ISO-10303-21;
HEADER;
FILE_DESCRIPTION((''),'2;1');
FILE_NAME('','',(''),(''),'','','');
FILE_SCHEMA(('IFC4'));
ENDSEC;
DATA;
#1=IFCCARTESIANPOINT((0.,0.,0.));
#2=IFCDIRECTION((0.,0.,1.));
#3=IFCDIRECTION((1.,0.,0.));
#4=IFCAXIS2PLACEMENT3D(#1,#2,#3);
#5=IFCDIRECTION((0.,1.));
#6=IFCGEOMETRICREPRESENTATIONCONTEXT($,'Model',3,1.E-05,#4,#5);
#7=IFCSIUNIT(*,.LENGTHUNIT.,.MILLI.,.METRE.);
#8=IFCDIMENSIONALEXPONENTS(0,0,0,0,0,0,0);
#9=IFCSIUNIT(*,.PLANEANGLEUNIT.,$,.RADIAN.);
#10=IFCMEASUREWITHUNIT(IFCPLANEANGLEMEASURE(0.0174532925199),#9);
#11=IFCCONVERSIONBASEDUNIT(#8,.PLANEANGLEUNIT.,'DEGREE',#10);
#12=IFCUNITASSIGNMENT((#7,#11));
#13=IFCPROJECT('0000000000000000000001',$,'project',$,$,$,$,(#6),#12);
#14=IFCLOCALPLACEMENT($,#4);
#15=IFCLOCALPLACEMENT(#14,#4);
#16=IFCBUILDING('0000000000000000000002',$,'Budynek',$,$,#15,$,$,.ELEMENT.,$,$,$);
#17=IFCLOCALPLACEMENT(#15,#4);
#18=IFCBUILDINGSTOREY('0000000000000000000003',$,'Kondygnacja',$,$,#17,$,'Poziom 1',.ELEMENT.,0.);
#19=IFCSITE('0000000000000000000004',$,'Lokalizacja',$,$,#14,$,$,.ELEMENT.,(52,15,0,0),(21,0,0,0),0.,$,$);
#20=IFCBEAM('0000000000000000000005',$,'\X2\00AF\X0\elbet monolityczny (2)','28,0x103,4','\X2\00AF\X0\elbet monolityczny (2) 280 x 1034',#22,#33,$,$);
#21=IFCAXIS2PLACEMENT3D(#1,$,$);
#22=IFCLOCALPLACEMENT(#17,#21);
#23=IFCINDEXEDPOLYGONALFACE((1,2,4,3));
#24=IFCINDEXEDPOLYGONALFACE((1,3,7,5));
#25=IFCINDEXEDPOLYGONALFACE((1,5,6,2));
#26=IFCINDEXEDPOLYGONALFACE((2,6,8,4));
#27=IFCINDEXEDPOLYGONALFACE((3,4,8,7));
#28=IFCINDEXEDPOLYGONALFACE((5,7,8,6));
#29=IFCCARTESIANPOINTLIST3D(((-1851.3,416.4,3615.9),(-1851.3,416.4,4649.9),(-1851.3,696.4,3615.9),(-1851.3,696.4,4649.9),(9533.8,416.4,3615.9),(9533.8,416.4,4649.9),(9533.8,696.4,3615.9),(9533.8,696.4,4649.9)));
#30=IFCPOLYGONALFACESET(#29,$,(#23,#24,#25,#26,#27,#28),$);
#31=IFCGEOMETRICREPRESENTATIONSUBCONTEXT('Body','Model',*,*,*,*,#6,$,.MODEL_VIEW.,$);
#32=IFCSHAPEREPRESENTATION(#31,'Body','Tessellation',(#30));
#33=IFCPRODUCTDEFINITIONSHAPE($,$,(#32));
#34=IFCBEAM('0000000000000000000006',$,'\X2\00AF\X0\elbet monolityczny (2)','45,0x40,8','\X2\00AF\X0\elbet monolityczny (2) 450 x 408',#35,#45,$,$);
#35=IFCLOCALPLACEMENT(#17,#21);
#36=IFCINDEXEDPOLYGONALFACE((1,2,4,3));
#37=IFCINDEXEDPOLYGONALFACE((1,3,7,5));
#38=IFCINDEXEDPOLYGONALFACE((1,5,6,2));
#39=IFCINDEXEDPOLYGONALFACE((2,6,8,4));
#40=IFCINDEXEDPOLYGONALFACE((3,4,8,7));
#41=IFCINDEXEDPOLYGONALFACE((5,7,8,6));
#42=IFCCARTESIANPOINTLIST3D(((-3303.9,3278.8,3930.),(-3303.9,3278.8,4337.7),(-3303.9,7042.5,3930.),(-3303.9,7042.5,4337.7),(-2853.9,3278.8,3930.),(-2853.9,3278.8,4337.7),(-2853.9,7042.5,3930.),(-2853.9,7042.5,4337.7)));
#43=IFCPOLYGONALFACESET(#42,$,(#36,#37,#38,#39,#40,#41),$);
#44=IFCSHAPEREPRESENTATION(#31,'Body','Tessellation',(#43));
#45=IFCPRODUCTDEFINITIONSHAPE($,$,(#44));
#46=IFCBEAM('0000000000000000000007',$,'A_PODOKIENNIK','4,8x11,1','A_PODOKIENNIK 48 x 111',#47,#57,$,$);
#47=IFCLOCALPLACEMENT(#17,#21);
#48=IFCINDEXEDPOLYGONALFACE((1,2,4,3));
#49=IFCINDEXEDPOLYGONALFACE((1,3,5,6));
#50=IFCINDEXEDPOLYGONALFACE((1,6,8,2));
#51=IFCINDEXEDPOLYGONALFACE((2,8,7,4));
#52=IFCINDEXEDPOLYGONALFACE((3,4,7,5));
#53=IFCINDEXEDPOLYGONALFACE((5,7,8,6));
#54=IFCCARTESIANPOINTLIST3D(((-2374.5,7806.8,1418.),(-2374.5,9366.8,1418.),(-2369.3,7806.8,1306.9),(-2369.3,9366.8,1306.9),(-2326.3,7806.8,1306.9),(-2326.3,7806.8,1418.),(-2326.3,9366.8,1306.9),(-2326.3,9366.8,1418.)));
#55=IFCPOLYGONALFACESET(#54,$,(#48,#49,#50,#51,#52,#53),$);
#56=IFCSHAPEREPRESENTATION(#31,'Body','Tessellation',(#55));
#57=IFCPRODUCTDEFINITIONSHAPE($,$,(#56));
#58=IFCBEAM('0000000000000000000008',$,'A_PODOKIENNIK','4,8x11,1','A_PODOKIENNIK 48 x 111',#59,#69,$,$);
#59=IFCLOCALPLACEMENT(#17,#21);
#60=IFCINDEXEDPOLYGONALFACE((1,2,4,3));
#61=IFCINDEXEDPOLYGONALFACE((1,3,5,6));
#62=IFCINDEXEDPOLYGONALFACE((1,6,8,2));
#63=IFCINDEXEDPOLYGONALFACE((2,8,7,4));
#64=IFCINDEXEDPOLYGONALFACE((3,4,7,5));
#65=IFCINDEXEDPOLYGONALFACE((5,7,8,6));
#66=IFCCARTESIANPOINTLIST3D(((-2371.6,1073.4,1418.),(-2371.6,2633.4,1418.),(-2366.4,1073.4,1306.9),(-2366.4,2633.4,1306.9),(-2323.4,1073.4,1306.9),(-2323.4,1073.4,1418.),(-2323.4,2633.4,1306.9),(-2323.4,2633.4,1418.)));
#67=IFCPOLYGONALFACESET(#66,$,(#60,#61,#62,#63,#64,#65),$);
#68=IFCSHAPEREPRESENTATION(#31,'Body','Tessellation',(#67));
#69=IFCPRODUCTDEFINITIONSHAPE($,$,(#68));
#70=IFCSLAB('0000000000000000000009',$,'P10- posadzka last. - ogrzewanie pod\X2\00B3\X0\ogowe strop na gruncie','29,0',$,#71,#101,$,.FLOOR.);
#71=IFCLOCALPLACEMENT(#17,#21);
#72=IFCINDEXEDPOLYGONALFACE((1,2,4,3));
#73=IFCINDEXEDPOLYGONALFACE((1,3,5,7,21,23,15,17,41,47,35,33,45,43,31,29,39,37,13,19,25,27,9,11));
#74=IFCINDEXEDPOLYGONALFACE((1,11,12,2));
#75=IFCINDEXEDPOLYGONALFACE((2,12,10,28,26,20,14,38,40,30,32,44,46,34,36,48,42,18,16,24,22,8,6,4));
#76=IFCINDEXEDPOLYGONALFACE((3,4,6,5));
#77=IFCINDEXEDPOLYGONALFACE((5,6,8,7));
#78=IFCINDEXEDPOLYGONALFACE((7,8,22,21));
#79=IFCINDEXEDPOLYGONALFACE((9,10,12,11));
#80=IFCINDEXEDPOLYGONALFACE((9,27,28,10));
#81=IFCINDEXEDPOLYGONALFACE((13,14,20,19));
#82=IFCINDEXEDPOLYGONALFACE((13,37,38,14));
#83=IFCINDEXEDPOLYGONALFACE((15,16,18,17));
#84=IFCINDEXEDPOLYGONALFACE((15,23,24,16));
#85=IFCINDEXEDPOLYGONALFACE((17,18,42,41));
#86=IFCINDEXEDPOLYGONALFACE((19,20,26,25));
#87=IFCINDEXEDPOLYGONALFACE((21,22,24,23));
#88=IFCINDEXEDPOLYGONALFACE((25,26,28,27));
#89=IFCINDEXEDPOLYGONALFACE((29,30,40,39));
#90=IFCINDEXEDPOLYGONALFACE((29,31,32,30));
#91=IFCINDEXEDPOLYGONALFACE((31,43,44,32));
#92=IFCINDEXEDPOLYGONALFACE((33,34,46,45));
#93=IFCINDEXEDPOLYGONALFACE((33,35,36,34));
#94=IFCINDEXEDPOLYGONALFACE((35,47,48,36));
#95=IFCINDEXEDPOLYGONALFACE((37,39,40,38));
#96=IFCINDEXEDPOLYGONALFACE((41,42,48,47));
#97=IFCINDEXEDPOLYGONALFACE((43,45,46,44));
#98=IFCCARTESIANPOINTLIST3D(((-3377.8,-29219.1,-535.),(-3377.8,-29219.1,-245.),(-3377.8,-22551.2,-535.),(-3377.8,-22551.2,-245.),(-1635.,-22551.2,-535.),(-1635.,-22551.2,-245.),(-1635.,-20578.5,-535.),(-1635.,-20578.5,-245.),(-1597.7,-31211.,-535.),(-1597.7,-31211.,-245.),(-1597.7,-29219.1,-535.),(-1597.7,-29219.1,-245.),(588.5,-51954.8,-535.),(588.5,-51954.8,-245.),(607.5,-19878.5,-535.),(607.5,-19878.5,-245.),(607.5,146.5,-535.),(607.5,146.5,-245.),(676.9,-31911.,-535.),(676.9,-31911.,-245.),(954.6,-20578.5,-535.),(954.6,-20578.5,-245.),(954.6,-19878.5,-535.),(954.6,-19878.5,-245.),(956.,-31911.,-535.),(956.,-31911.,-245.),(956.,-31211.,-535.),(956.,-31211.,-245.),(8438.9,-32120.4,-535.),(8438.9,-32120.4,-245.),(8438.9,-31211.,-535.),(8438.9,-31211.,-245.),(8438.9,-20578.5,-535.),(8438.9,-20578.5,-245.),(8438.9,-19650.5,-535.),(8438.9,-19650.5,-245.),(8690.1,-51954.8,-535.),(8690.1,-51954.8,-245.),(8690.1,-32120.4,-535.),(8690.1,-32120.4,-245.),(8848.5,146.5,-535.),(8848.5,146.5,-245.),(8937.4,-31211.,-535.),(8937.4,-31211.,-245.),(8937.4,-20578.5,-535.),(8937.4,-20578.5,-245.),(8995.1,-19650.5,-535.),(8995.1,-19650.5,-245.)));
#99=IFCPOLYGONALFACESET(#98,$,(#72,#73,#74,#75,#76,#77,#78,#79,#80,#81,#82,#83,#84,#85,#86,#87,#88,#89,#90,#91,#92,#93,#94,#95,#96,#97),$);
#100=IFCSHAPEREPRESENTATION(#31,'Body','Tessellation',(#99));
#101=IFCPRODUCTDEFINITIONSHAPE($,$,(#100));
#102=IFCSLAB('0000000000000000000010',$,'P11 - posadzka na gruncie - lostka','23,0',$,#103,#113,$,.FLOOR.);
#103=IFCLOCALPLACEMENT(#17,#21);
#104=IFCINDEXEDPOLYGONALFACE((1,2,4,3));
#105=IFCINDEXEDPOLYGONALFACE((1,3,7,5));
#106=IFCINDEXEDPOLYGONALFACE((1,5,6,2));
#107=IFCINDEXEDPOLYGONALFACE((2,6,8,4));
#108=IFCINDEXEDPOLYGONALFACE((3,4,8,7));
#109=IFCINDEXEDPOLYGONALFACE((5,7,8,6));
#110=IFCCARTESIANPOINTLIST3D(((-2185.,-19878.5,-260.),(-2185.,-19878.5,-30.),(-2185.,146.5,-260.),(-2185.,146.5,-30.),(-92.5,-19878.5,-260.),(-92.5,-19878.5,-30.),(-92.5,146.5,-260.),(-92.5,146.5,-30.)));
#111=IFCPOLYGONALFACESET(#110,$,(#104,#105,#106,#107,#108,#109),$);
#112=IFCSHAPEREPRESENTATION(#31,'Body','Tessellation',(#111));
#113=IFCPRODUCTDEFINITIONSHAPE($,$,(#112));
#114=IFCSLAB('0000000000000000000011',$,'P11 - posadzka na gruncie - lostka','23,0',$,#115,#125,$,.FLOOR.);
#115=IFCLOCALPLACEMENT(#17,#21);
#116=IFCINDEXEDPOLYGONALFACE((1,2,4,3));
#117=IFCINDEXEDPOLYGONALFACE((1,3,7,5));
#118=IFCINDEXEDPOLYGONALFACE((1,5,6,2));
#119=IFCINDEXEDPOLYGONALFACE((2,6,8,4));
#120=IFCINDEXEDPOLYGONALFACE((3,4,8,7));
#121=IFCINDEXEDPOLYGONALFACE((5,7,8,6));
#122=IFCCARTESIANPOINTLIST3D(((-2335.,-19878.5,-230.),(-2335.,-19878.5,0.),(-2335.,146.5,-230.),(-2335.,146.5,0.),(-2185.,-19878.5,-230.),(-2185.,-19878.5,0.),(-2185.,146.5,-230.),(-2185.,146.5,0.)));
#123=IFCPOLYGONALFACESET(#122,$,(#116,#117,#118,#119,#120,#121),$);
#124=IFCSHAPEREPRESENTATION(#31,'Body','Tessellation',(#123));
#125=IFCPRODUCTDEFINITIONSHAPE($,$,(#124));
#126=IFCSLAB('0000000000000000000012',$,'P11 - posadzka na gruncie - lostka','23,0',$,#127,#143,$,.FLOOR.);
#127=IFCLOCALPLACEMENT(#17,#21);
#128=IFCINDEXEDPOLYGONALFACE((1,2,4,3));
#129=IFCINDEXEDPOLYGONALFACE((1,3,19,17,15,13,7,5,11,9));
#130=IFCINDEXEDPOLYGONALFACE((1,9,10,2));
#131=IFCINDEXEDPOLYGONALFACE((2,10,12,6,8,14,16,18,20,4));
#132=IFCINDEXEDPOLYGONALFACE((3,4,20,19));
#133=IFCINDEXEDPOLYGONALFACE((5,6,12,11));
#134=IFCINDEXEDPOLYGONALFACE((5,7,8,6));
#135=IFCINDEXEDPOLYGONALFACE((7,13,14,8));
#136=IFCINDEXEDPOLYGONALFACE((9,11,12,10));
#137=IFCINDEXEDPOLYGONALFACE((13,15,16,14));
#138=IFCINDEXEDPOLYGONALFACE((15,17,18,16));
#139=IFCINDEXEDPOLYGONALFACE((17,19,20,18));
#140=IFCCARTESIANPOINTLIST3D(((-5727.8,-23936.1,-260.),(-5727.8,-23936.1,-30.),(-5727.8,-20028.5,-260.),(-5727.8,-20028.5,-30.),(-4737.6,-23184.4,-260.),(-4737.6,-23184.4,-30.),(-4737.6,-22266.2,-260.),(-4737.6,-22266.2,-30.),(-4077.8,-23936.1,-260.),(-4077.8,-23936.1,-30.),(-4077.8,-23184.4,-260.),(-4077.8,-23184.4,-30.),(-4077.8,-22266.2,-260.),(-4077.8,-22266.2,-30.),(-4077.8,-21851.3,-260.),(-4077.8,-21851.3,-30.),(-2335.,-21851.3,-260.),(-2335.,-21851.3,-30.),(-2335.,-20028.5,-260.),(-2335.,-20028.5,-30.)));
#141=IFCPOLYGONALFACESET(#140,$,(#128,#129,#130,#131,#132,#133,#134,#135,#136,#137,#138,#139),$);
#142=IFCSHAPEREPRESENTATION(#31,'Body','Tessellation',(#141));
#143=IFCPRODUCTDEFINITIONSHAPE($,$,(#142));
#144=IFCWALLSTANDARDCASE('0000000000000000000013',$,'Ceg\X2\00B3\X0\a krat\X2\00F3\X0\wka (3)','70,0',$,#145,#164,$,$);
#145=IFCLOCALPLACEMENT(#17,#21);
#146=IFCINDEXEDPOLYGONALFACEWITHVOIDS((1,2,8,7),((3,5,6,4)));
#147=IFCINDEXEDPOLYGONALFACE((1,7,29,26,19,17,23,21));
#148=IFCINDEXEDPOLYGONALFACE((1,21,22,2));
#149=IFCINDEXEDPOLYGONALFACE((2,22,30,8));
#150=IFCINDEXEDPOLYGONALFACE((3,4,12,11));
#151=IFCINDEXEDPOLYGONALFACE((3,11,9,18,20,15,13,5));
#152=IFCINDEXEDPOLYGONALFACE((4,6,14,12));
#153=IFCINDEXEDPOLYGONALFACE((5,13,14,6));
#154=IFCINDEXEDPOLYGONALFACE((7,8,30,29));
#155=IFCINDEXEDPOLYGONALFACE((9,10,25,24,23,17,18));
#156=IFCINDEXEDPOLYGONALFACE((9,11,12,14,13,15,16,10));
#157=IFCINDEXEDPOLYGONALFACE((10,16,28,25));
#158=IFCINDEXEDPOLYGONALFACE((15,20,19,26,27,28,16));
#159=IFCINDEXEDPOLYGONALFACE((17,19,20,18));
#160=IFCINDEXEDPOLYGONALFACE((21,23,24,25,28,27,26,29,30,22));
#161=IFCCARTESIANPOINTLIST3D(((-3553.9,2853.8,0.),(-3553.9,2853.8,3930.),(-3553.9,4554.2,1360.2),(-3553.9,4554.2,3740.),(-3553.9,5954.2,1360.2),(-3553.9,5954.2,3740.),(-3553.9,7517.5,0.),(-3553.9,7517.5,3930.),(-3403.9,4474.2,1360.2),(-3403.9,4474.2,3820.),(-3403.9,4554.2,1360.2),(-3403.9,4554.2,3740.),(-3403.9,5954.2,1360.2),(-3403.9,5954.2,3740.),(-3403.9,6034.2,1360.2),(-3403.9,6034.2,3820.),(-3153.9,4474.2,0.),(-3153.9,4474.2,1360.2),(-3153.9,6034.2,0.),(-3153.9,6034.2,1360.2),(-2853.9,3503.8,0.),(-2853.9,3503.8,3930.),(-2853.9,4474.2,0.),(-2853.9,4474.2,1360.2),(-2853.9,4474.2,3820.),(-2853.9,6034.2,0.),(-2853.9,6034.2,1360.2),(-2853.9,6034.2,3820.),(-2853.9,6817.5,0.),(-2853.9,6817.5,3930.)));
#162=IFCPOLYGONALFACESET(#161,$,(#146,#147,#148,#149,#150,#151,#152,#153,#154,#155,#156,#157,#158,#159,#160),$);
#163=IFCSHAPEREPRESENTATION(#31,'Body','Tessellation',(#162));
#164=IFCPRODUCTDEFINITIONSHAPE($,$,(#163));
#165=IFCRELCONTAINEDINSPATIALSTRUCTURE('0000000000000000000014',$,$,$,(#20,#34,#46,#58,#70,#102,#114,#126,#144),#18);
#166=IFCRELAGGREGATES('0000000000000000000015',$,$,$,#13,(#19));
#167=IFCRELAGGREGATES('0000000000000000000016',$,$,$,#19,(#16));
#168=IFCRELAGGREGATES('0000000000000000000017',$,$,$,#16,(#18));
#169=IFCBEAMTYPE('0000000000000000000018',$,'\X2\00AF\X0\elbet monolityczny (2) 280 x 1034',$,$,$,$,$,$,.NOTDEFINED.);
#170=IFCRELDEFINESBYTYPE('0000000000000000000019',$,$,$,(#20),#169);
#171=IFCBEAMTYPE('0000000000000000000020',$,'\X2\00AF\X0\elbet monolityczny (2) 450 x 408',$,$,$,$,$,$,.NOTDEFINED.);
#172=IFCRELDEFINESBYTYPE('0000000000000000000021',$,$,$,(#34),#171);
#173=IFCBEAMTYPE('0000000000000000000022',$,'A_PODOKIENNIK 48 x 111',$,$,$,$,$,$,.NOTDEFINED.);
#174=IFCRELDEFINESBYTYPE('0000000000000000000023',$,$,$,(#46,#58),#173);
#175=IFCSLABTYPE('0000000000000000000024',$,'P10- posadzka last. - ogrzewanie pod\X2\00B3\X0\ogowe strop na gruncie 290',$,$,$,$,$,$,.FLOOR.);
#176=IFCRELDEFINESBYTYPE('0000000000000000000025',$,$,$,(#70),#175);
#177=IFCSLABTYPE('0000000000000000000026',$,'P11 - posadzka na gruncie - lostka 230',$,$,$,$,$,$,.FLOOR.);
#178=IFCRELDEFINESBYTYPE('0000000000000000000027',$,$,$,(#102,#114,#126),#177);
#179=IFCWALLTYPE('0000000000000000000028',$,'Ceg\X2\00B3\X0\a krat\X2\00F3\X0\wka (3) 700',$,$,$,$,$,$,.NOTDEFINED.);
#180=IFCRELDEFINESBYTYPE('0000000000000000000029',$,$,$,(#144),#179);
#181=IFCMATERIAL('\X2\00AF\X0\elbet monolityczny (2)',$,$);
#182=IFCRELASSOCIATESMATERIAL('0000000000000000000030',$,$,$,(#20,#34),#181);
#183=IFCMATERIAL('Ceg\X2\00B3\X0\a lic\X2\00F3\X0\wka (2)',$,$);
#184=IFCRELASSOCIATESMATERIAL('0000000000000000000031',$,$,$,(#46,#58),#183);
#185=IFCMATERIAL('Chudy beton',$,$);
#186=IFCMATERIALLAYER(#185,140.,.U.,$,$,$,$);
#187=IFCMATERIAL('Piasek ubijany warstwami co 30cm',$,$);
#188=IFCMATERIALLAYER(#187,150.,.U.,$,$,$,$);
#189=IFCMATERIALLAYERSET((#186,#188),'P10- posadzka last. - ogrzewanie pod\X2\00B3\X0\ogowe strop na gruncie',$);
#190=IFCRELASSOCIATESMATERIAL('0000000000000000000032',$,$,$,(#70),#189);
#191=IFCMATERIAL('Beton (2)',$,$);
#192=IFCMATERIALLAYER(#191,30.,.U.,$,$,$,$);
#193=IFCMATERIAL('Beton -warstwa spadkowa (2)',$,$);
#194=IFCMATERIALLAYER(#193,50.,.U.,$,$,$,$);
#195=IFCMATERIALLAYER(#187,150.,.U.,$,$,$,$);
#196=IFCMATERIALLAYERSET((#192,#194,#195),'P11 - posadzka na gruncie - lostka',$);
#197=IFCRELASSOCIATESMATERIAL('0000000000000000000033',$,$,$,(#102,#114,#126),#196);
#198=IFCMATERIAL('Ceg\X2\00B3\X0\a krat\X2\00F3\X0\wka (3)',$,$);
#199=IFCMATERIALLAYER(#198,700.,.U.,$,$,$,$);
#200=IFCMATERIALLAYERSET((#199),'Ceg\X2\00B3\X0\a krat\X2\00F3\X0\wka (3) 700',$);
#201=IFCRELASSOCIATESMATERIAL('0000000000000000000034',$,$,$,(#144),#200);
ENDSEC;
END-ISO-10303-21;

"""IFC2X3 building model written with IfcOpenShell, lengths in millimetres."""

from ifc_helpers import new_model, entity, si_unit, converted_unit, direction, frame, frame_2d, origin_with_axes, origin_2d_with_axis, place, context, subcontext, project, spatial, polyline, rectangle, outline, extrude, material, layer, layer_set, layer_usage, type_object, element, save


model = new_model("IFC2X3")

# Units and contexts
model_context = context("Model", 3, precision=1e-05, world=origin_with_axes(), true_north=direction((0.0, 1.0)))
body_context = subcontext(model_context, "Body", "Model", "MODEL_VIEW")
ifc_project = project(units=[si_unit("LENGTHUNIT", "METRE", prefix="MILLI"), converted_unit("PLANEANGLEUNIT", "DEGREE", entity("IfcPlaneAngleMeasure", 0.0174532925199), si_unit("PLANEANGLEUNIT", "RADIAN"), dimensions=[0, 0, 0, 0, 0, 0, 0])], contexts=[model_context])

# Site, building, storey
site_placement = place(None, origin_with_axes())
site = spatial("IfcSite", under=ifc_project, at=site_placement, Name="Lokalizacja", CompositionType="ELEMENT", RefLatitude=(52, 15, 0, 0), RefLongitude=(21, 0, 0, 0), RefElevation=0.0)
building_placement = place(site_placement, origin_with_axes())
building = spatial("IfcBuilding", under=site, at=building_placement, Name="Budynek", CompositionType="ELEMENT")
storey_placement = place(building_placement, origin_with_axes())
storey = spatial("IfcBuildingStorey", under=building, at=storey_placement, Name="Kondygnacja", LongName="Poziom 1", CompositionType="ELEMENT", Elevation=0.0)

# Beams
ifc_material_1 = material(Name="¯elbet monolityczny (2)")
beam_type_1 = type_object("IfcBeamType", Name="¯elbet monolityczny (2) 280 x 1034", PredefinedType="NOTDEFINED")
beam_1_placement = place(storey_placement, frame((-1851.3, 556.4, 4649.9), z_axis=(0.0, 0.0, 1.0), x_axis=(0.0, -1.0, 0.0)))
element("IfcBeam", 1, at=beam_1_placement, inside=storey, type_object=beam_type_1, material=ifc_material_1, Name="¯elbet monolityczny (2)", Description="28,0x103,4", ObjectType="¯elbet monolityczny (2) 280 x 1034", context=body_context, shape_type="SweptSolid", body=[
    extrude(rectangle(XDim=1034.0, YDim=280.0, at=frame_2d((-517.0, 0.0), x_axis=(1.0, 0.0))), frame((0.0, 0.0, 0.0), z_axis=(0.0, 1.0, 0.0), x_axis=(0.0, 0.0, 1.0)), (0.0, 0.0, 1.0), 11385.1),
])
beam_type_2 = type_object("IfcBeamType", Name="¯elbet monolityczny (2) 450 x 408", PredefinedType="NOTDEFINED")
beam_2_placement = place(storey_placement, frame((-3078.9, 3278.8, 4337.7), z_axis=(0.0, 0.0, 1.0), x_axis=(1.0, 0.0, 0.0)))
element("IfcBeam", 2, at=beam_2_placement, inside=storey, type_object=beam_type_2, material=ifc_material_1, Name="¯elbet monolityczny (2)", Description="45,0x40,8", ObjectType="¯elbet monolityczny (2) 450 x 408", context=body_context, shape_type="SweptSolid", body=[
    extrude(rectangle(XDim=407.7, YDim=450.0, at=frame_2d((-203.9, 0.0), x_axis=(1.0, 0.0))), frame((0.0, 0.0, 0.0), z_axis=(0.0, 1.0, 0.0), x_axis=(0.0, 0.0, 1.0)), (0.0, 0.0, 1.0), 3763.7),
])
ifc_material_2 = material(Name="Ceg³a licówka (2)")
beam_type_3 = type_object("IfcBeamType", Name="A_PODOKIENNIK 48 x 111", PredefinedType="NOTDEFINED")
for number, where, z_axis, x_axis, name in (
    (3, (-2326.3, 9366.8, 1306.9), (0.0, 0.0, 1.0), (-1.0, 0.0, 0.0), "A_PODOKIENNIK"),
    (4, (-2323.4, 2633.4, 1306.9), (0.0, 0.0, 1.0), (-1.0, 0.0, 0.0), "A_PODOKIENNIK"),
):
    element("IfcBeam", number, at=place(storey_placement, frame(where, z_axis=z_axis, x_axis=x_axis)), inside=storey, type_object=beam_type_3, material=ifc_material_2, Name=name, Description="4,8x11,1", ObjectType="A_PODOKIENNIK 48 x 111", context=body_context, shape_type="SweptSolid", body=[
        extrude(outline(polyline([(0.0, 0.0), (43.0, 0.0), (48.2, 111.1), (0.0, 111.1), (0.0, 0.0)])), frame((0.0, 1560.0, 0.0), z_axis=(0.0, -1.0, 0.0), x_axis=(1.0, 0.0, 0.0)), (0.0, 0.0, 1.0), 1560.0),
    ])
ifc_material_3 = material(Name="Ceg³a kratówka (3)")

# Slabs
ifc_material_4 = material(Name="Chudy beton")
ifc_layer_1 = layer(ifc_material_4, 140.0, ventilated="UNKNOWN")
ifc_material_5 = material(Name="Piasek ubijany warstwami co 30cm")
ifc_layer_2 = layer(ifc_material_5, 150.0, ventilated="UNKNOWN")
ifc_layer_set_1 = layer_set([ifc_layer_1, ifc_layer_2], Name="P10- posadzka last. - ogrzewanie pod³ogowe strop na gruncie")
ifc_layer_usage_1 = layer_usage(ifc_layer_set_1, "AXIS3", "NEGATIVE", 290.0)
slab_type_1 = type_object("IfcSlabType", Name="P10- posadzka last. - ogrzewanie pod³ogowe strop na gruncie 290", PredefinedType="FLOOR")
slab_1_placement = place(storey_placement, frame((-3377.8, -22551.2, -245.0), z_axis=(0.0, 0.0, 1.0), x_axis=(1.0, 0.0, 0.0)))
element("IfcSlab", 5, at=slab_1_placement, inside=storey, type_object=slab_type_1, material=ifc_layer_usage_1, Name="P10- posadzka last. - ogrzewanie pod³ogowe strop na gruncie", Description="29,0", PredefinedType="FLOOR", context=body_context, shape_type="SweptSolid", body=[
    extrude(outline(polyline([(0.0, 0.0), (0.0, -6667.9), (1780.0, -6667.9), (1780.0, -8659.8), (4333.8, -8659.8), (4333.8, -9359.8), (4054.7, -9359.8), (3966.2, -29403.6), (12067.9, -29403.6), (12067.9, -9569.1), (11816.7, -9569.1), (11816.7, -8659.8), (12315.2, -8659.8), (12315.2, 1972.7), (11816.7, 1972.7), (11816.7, 2900.8), (12372.9, 2900.8), (12226.2, 22697.7), (3985.3, 22697.7), (3985.3, 2672.7), (4332.3, 2672.7), (4332.3, 1972.7), (1742.8, 1972.7), (1742.8, 0.0), (0.0, 0.0)])), frame((0.0, 0.0, -290.0), z_axis=(0.0, 0.0, 1.0), x_axis=(1.0, 0.0, 0.0)), (0.0, 0.0, 1.0), 290.0),
])
ifc_material_6 = material(Name="Beton (2)")
ifc_layer_3 = layer(ifc_material_6, 30.0, ventilated="UNKNOWN")
ifc_material_7 = material(Name="Beton -warstwa spadkowa (2)")
ifc_layer_4 = layer(ifc_material_7, 50.0, ventilated="UNKNOWN")
ifc_layer_5 = layer(ifc_material_5, 150.0, ventilated="UNKNOWN")
ifc_layer_set_2 = layer_set([ifc_layer_3, ifc_layer_4, ifc_layer_5], Name="P11 - posadzka na gruncie - lostka")
ifc_layer_usage_2 = layer_usage(ifc_layer_set_2, "AXIS3", "NEGATIVE", 230.0)
slab_type_2 = type_object("IfcSlabType", Name="P11 - posadzka na gruncie - lostka 230", PredefinedType="FLOOR")
slab_2_placement = place(storey_placement, frame((-2185.0, -19878.5, -30.0), z_axis=(0.0, 0.0, 1.0), x_axis=(1.0, 0.0, 0.0)))
element("IfcSlab", 6, at=slab_2_placement, inside=storey, type_object=slab_type_2, material=ifc_layer_usage_2, Name="P11 - posadzka na gruncie - lostka", Description="23,0", PredefinedType="FLOOR", context=body_context, shape_type="SweptSolid", body=[
    extrude(outline(polyline([(0.0, 0.0), (2092.5, 0.0), (2092.5, 20025.0), (0.0, 20025.0), (0.0, 0.0)])), frame((0.0, 0.0, -230.0), z_axis=(0.0, 0.0, 1.0), x_axis=(1.0, 0.0, 0.0)), (0.0, 0.0, 1.0), 230.0),
])
ifc_layer_usage_3 = layer_usage(ifc_layer_set_2, "AXIS3", "NEGATIVE", 230.0)
slab_3_placement = place(storey_placement, frame((-2335.0, -19878.5, 0.0), z_axis=(0.0, 0.0, 1.0), x_axis=(1.0, 0.0, 0.0)))
element("IfcSlab", 7, at=slab_3_placement, inside=storey, type_object=slab_type_2, material=ifc_layer_usage_3, Name="P11 - posadzka na gruncie - lostka", Description="23,0", PredefinedType="FLOOR", context=body_context, shape_type="SweptSolid", body=[
    extrude(outline(polyline([(0.0, 0.0), (150.0, 0.0), (150.0, 20025.0), (0.0, 20025.0), (0.0, 0.0)])), frame((0.0, 0.0, -230.0), z_axis=(0.0, 0.0, 1.0), x_axis=(1.0, 0.0, 0.0)), (0.0, 0.0, 1.0), 230.0),
])
ifc_layer_usage_4 = layer_usage(ifc_layer_set_2, "AXIS3", "NEGATIVE", 230.0)
slab_4_placement = place(storey_placement, frame((-2335.0, -20028.5, -30.0), z_axis=(0.0, 0.0, 1.0), x_axis=(1.0, 0.0, 0.0)))
element("IfcSlab", 8, at=slab_4_placement, inside=storey, type_object=slab_type_2, material=ifc_layer_usage_4, Name="P11 - posadzka na gruncie - lostka", Description="23,0", PredefinedType="FLOOR", context=body_context, shape_type="SweptSolid", body=[
    extrude(outline(polyline([(0.0, 0.0), (-3392.8, 0.0), (-3392.8, -3907.5), (-1742.8, -3907.5), (-1742.8, -3155.9), (-2402.6, -3155.9), (-2402.6, -2237.7), (-1742.8, -2237.7), (-1742.8, -1822.7), (0.0, -1822.7), (0.0, 0.0)])), frame((0.0, 0.0, -230.0), z_axis=(0.0, 0.0, 1.0), x_axis=(1.0, 0.0, 0.0)), (0.0, 0.0, 1.0), 230.0),
])

# Wall, opening
ifc_layer_6 = layer(ifc_material_3, 700.0, ventilated="UNKNOWN")
ifc_layer_set_3 = layer_set([ifc_layer_6], Name="Ceg³a kratówka (3) 700")
ifc_layer_usage_5 = layer_usage(ifc_layer_set_3, "AXIS2", "NEGATIVE", 0.0)
wall_type_1 = type_object("IfcWallType", Name="Ceg³a kratówka (3) 700", PredefinedType="NOTDEFINED")
wall_1_placement = place(storey_placement, frame((-2853.9, 6817.5, 0.0), z_axis=(0.0, 0.0, 1.0), x_axis=(0.0, -1.0, 0.0)))
wall_1 = element("IfcWallStandardCase", 9, at=wall_1_placement, inside=storey, type_object=wall_type_1, material=ifc_layer_usage_5, Name="Ceg³a kratówka (3)", Description="70,0", context=body_context, shape_type="SweptSolid", body=[
    extrude(outline(polyline([(-700.0, -700.0), (3963.7, -700.0), (3313.7, 0.0), (0.0, 0.0), (-700.0, -700.0)])), origin_with_axes(), (0.0, 0.0, 1.0), 3930.0),
])
opening_placement = place(wall_1_placement, frame((1563.3, 0.0, 1360.2), z_axis=(0.0, 0.0, 1.0), x_axis=(1.0, 0.0, 0.0)))
element("IfcOpeningElement", 10, at=opening_placement, cuts=wall_1, context=body_context, shape_type="SweptSolid", body=[
    extrude(rectangle(XDim=1560.0, YDim=1300.0, at=origin_2d_with_axis()), frame((0.0, 350.0, -1360.2), z_axis=(0.0, 0.0, -1.0), x_axis=(-1.0, 0.0, 0.0)), (0.0, 0.0, -1.0), 1360.2),
    extrude(rectangle(XDim=1560.0, YDim=2459.8, at=origin_2d_with_axis()), frame((0.0, -550.0, 1229.9), z_axis=(0.0, 1.0, 0.0), x_axis=(-1.0, 0.0, 0.0)), (0.0, 0.0, 1.0), 1250.0),
    extrude(rectangle(XDim=1400.0, YDim=2379.8, at=origin_2d_with_axis()), frame((0.0, -550.0, 1189.9), z_axis=(0.0, -1.0, 0.0), x_axis=(-1.0, 0.0, 0.0)), (0.0, 0.0, 1.0), 850.0),
])

save(model, "model.ifc")
